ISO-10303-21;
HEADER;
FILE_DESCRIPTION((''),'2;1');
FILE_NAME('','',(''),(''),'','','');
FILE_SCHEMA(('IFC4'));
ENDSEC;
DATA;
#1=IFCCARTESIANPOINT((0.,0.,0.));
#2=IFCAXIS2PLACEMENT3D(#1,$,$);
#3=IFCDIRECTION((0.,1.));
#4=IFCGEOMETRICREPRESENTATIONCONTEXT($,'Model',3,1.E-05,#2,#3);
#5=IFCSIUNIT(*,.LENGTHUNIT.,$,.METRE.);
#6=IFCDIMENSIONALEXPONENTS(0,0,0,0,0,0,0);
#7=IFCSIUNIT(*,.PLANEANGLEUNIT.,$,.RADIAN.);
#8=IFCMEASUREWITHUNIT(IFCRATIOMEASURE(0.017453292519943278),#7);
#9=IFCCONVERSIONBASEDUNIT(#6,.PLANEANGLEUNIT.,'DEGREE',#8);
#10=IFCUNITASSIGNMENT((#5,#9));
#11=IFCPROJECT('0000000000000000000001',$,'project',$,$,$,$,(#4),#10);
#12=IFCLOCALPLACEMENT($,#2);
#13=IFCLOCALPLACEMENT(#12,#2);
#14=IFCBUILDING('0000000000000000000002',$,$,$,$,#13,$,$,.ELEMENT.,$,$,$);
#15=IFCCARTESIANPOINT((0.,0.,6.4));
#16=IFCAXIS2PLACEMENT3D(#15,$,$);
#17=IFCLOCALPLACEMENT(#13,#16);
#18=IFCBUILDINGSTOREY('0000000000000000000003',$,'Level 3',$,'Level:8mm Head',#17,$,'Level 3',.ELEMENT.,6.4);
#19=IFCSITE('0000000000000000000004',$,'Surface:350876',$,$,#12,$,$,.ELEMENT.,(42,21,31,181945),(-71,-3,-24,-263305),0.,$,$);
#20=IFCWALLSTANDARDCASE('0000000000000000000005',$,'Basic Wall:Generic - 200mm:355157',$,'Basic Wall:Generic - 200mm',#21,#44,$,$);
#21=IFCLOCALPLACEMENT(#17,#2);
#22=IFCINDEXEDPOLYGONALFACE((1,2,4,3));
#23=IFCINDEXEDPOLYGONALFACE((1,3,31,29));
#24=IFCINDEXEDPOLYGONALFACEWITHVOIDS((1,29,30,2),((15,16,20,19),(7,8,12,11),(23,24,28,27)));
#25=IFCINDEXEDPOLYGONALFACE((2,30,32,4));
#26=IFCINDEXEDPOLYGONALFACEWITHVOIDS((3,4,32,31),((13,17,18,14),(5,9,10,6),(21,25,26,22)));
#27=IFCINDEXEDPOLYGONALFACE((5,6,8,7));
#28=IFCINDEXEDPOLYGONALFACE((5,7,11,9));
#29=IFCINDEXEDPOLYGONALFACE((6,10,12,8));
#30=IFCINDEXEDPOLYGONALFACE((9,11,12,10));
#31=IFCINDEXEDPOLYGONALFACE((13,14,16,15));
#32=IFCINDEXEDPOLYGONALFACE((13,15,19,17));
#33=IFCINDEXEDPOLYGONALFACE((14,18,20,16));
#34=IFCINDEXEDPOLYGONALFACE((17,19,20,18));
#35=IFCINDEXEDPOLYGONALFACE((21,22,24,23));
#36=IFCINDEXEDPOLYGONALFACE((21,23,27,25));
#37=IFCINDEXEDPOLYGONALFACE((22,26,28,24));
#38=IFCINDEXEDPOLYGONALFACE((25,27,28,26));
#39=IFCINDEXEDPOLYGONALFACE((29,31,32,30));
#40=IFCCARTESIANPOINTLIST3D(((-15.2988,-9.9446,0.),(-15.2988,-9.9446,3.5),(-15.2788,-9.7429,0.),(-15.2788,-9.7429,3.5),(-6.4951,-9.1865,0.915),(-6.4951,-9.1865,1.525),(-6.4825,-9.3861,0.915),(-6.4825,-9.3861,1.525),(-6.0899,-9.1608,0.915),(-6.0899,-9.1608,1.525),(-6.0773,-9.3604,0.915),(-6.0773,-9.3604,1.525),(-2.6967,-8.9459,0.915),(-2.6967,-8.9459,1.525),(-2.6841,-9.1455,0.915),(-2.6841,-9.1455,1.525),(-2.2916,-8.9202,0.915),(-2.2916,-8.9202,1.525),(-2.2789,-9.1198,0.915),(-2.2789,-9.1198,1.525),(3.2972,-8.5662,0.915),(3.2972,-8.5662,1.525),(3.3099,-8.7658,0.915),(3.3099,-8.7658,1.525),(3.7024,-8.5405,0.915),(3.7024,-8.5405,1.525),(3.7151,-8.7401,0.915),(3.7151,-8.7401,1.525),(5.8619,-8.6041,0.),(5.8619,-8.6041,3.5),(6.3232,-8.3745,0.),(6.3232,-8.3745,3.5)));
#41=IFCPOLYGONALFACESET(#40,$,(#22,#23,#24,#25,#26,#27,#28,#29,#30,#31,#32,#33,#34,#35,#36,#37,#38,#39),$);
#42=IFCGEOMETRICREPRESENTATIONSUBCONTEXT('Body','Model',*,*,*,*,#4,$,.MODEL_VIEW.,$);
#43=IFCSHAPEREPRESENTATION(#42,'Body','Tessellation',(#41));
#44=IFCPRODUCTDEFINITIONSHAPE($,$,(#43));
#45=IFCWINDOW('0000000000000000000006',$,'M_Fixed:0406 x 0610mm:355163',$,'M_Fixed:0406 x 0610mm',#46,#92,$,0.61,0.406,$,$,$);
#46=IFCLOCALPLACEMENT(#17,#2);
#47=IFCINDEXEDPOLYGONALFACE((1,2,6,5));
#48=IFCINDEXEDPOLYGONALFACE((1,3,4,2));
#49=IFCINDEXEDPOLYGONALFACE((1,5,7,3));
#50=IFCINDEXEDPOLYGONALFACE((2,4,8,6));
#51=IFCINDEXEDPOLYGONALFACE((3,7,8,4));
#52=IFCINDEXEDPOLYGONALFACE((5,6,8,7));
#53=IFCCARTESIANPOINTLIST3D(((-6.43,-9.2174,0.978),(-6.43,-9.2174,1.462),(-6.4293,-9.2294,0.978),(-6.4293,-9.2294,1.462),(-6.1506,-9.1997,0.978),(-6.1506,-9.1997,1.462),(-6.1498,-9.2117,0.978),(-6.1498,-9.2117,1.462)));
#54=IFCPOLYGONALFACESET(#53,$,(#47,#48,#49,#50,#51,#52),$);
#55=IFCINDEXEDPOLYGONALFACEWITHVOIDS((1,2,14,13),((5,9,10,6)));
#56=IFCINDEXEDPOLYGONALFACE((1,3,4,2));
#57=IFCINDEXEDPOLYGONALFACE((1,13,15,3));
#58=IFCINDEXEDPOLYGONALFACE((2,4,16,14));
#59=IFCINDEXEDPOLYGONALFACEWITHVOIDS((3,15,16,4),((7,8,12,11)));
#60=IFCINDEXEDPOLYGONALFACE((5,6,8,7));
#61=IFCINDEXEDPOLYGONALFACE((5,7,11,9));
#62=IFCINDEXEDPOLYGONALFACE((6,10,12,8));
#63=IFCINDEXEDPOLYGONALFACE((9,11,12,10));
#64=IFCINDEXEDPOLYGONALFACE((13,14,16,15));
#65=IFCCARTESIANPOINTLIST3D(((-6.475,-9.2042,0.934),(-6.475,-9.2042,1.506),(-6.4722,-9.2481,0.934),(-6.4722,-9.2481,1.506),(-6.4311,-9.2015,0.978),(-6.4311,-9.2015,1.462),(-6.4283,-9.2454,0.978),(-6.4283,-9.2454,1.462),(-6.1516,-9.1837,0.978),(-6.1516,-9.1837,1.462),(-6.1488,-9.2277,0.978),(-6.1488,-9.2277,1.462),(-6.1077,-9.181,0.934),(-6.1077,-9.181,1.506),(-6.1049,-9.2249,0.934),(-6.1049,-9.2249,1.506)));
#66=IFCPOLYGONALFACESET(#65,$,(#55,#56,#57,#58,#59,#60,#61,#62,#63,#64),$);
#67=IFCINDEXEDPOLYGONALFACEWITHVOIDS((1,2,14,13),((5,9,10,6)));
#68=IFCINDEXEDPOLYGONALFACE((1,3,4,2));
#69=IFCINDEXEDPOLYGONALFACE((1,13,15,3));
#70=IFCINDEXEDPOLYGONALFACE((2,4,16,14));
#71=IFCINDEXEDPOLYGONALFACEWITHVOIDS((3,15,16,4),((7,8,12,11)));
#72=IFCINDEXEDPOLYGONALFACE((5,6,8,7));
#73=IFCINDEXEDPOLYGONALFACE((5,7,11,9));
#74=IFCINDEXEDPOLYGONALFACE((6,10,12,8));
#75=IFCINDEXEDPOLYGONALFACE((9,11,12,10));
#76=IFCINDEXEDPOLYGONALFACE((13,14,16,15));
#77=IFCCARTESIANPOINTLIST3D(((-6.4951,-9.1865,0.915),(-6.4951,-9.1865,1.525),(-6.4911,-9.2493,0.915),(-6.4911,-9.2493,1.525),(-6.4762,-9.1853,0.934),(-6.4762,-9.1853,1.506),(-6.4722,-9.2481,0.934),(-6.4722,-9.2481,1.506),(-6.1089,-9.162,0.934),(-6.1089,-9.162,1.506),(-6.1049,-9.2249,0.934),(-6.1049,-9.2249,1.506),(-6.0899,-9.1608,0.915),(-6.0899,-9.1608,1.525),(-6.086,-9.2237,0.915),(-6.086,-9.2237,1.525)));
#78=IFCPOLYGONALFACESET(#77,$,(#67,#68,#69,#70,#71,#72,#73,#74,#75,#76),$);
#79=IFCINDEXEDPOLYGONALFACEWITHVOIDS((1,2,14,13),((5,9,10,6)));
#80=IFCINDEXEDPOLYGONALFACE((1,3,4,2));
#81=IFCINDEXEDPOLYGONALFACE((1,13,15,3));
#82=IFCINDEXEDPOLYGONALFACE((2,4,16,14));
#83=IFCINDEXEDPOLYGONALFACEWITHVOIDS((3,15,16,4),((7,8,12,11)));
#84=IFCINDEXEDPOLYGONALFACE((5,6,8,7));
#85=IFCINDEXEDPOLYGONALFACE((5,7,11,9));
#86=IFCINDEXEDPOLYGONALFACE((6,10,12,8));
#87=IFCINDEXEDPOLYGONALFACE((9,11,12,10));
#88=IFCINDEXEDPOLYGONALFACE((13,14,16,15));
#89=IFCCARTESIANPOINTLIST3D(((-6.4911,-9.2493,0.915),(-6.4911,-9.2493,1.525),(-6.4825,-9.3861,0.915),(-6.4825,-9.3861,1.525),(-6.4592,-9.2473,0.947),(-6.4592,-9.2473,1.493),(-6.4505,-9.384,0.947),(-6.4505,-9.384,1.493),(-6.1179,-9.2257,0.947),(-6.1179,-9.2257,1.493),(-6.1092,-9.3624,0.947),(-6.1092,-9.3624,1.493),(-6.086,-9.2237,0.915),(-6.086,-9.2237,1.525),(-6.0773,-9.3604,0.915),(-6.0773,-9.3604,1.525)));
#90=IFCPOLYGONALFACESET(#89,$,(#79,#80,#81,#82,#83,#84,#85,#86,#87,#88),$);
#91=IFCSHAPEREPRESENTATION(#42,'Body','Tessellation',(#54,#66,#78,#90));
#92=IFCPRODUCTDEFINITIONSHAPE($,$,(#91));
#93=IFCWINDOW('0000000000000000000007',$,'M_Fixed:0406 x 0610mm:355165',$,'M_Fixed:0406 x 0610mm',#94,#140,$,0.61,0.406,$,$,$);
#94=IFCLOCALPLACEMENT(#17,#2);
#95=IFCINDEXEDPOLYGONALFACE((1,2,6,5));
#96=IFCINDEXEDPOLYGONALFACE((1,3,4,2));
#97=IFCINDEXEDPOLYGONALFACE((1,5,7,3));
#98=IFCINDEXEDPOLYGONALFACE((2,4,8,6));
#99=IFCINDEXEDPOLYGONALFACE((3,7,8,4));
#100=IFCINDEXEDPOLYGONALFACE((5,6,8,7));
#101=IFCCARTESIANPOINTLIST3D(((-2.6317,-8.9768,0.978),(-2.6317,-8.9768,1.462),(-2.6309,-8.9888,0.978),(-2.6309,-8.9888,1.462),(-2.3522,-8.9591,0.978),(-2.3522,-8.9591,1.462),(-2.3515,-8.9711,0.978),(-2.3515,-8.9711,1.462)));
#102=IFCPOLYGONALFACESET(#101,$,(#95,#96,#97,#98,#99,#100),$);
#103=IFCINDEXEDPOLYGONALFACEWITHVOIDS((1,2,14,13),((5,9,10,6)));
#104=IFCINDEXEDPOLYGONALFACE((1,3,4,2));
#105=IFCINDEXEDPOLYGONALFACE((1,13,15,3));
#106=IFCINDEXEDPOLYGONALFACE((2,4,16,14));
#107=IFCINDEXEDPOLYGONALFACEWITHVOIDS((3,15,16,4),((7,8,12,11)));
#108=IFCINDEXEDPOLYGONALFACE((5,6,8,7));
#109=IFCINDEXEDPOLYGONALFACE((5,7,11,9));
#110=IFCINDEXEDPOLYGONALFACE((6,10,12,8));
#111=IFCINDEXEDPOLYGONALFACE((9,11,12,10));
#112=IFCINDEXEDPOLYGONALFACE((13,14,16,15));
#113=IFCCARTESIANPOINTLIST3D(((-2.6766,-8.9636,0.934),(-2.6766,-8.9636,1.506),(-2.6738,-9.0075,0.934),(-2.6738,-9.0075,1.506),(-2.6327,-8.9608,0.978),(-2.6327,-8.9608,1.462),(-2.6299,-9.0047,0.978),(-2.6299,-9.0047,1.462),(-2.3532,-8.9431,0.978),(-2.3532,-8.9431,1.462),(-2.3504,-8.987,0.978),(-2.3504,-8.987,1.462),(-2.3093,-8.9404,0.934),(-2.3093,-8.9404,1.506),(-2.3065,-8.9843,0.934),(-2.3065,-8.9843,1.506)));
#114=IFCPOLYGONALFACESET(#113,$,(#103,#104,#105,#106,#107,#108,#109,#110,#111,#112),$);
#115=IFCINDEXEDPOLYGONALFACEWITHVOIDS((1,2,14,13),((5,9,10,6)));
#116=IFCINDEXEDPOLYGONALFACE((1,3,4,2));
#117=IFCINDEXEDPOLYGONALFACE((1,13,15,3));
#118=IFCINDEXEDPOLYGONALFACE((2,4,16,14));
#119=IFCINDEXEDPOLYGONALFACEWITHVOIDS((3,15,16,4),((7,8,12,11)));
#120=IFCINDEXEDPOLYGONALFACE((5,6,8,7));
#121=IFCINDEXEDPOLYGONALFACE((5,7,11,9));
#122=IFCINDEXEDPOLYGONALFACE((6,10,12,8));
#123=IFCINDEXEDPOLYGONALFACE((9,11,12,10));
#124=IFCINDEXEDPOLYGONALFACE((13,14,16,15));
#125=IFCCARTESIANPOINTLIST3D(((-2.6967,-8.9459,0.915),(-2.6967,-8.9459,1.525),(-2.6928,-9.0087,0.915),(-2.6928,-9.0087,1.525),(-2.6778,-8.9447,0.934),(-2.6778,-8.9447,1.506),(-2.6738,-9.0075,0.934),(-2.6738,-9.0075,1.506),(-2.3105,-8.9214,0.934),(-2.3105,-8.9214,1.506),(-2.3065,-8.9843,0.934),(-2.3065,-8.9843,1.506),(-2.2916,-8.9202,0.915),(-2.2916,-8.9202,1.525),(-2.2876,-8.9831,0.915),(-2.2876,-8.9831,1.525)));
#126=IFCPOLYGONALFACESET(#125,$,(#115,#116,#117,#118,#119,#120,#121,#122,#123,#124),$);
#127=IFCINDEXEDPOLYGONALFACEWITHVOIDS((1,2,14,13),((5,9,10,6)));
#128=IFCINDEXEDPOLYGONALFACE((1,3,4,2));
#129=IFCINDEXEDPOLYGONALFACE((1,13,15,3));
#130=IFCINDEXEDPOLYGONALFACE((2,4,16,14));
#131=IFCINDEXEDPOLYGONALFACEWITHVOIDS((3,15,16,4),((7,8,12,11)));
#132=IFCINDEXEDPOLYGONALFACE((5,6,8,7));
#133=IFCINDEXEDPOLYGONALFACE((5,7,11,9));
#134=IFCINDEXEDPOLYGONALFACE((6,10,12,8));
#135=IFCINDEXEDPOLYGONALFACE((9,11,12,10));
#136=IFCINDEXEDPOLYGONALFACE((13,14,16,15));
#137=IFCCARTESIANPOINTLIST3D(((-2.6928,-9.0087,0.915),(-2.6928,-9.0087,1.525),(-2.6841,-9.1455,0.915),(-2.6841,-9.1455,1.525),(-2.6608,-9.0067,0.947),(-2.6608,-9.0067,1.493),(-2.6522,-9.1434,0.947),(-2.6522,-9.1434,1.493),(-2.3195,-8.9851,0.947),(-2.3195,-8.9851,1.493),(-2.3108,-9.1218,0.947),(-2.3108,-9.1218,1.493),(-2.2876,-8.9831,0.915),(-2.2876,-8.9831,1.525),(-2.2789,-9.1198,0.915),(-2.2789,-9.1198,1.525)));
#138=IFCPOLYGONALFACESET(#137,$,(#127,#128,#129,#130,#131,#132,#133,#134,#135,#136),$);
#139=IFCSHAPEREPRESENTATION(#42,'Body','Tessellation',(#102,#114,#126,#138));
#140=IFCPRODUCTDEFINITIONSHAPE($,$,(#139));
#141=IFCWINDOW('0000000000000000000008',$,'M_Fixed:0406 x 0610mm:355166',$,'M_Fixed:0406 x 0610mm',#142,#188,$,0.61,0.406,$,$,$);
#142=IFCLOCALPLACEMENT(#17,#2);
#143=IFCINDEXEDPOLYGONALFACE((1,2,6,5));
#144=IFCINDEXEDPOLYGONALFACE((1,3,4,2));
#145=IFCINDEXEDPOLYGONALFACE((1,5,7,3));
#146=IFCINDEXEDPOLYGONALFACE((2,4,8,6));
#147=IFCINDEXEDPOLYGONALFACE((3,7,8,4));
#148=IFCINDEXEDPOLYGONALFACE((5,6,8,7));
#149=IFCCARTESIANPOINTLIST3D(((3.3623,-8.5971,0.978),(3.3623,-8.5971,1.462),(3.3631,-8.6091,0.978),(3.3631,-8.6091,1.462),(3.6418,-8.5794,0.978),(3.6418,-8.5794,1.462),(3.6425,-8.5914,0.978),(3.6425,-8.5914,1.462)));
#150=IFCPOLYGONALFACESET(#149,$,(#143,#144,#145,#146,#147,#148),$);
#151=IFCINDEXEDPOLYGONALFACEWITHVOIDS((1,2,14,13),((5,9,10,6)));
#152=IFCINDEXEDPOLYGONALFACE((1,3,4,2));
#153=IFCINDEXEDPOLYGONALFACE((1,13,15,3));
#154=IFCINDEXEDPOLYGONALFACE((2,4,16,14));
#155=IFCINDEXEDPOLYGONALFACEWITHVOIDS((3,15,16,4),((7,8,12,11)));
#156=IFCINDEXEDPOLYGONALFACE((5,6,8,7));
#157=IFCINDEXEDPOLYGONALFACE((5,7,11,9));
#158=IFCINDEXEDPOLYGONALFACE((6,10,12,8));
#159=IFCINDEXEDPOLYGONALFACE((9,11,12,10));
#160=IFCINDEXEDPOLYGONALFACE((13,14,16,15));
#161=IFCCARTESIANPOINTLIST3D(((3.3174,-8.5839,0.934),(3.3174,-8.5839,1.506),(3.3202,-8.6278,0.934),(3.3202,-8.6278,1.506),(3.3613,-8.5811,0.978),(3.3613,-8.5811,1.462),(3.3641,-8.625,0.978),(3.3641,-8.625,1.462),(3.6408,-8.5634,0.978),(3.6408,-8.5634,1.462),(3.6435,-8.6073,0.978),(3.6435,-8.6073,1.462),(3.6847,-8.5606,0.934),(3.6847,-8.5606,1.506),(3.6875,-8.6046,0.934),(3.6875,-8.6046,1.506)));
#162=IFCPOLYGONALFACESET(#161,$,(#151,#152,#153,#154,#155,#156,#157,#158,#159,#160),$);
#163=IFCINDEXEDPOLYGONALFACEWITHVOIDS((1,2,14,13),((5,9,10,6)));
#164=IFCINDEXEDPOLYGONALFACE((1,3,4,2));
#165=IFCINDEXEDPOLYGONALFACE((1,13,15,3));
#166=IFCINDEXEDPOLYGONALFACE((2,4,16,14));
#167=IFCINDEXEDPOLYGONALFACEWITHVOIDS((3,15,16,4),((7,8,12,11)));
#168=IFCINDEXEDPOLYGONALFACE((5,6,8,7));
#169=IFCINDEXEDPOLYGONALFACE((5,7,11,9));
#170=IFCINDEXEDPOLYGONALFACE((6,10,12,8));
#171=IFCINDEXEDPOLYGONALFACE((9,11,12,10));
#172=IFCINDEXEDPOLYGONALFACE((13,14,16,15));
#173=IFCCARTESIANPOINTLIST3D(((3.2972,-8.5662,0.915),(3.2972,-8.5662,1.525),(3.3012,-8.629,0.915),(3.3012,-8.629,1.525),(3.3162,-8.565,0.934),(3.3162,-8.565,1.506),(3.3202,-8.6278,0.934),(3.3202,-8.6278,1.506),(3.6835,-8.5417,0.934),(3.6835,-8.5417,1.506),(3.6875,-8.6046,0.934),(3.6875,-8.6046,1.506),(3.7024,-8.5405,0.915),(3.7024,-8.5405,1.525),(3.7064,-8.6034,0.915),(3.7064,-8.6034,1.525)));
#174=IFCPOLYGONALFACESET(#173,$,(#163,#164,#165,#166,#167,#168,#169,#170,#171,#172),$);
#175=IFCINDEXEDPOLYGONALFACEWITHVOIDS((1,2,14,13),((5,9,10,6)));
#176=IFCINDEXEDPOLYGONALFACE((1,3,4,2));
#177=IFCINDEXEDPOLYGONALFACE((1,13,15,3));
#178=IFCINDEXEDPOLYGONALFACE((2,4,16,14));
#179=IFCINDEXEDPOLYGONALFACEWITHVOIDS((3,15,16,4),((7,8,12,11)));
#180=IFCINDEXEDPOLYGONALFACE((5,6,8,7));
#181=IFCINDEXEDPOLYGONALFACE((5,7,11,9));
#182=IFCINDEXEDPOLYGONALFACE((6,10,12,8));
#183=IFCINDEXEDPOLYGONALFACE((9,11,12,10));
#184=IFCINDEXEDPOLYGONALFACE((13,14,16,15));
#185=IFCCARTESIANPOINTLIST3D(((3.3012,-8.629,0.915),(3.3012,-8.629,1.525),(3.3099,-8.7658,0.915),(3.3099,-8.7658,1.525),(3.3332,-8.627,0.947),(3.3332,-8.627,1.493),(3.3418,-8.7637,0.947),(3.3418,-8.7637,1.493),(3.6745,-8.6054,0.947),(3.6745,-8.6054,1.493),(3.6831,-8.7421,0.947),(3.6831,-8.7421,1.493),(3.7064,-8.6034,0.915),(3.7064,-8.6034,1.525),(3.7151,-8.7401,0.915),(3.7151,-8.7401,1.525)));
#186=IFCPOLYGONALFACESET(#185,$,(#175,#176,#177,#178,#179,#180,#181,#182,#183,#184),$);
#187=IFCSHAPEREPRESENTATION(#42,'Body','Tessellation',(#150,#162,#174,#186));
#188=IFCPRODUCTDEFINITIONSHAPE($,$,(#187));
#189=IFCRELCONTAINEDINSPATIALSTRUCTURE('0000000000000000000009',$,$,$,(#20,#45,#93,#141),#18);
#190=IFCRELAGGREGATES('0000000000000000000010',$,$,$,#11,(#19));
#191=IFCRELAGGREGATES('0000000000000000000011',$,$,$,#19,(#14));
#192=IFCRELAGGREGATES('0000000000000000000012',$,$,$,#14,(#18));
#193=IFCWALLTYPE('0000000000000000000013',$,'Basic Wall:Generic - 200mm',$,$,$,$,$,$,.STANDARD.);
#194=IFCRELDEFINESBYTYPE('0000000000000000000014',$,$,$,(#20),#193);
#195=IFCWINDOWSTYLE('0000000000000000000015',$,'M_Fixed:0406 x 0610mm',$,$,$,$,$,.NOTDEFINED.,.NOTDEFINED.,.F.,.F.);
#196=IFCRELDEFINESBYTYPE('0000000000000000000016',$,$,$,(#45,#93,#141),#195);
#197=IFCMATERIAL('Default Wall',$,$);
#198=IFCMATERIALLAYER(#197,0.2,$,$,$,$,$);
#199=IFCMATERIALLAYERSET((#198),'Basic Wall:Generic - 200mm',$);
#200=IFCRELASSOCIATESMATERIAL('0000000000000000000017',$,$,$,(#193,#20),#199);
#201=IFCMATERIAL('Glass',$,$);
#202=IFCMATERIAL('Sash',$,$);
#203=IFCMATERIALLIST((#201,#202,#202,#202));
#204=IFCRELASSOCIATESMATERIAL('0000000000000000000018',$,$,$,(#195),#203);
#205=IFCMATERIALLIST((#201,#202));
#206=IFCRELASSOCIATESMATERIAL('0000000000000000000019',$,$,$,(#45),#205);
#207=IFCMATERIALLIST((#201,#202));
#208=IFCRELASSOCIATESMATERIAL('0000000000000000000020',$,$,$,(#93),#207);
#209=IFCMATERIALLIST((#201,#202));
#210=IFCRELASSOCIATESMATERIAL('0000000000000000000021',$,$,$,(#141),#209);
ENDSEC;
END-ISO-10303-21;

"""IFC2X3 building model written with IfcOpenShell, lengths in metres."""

from ifc_helpers import new_model, entity, si_unit, converted_unit, direction, frame, frame_2d, origin, place, context, subcontext, project, spatial, polyline, rectangle, outline, extrude, source, transform, mapped, material, material_list, layer, layer_set, layer_usage, type_object, type_shapes, element, fill, save


model = new_model("IFC2X3")

# Units and contexts
model_context = context("Model", 3, precision=1e-05, world=origin(), true_north=direction((0.0, 1.0)))
body_context = subcontext(model_context, "Body", "Model", "MODEL_VIEW")
ifc_project = project(units=[si_unit("LENGTHUNIT", "METRE"), converted_unit("PLANEANGLEUNIT", "DEGREE", entity("IfcRatioMeasure", 0.017453292519943278), si_unit("PLANEANGLEUNIT", "RADIAN"), dimensions=[0, 0, 0, 0, 0, 0, 0])], contexts=[model_context])

# Site, building, storey
site_placement = place(None, origin())
site = spatial("IfcSite", under=ifc_project, at=site_placement, Name="Surface:350876", CompositionType="ELEMENT", RefLatitude=(42, 21, 31, 181945), RefLongitude=(-71, -3, -24, -263305), RefElevation=0.0)
building_placement = place(site_placement, origin())
building = spatial("IfcBuilding", under=site, at=building_placement, CompositionType="ELEMENT")
storey_placement = place(building_placement, frame((0.0, 0.0, 6.4)))
storey = spatial("IfcBuildingStorey", under=building, at=storey_placement, Name="Level 3", ObjectType="Level:8mm Head", LongName="Level 3", CompositionType="ELEMENT", Elevation=6.4)

# Wall, openings, windows
ifc_material_1 = material(Name="Default Wall")
ifc_layer_1 = layer(ifc_material_1, 0.2)
ifc_layer_set_1 = layer_set([ifc_layer_1], Name="Basic Wall:Generic - 200mm")
wall_type_1 = type_object("IfcWallType", Name="Basic Wall:Generic - 200mm", PredefinedType="STANDARD", material=ifc_layer_set_1)
ifc_material_2 = material(Name="Glass")
ifc_material_3 = material(Name="Sash")
ifc_material_list_1 = material_list([ifc_material_2, ifc_material_3, ifc_material_3, ifc_material_3])
window_style = type_object("IfcWindowStyle", Name="M_Fixed:0406 x 0610mm", ConstructionType="NOTDEFINED", OperationType="NOTDEFINED", ParameterTakesPrecedence=False, Sizeable=False, material=ifc_material_list_1)
shared_shape_1 = source(origin(), body_context, "Body", "SweptSolid", [
    extrude(rectangle(XDim=0.012, YDim=0.28, at=frame_2d((0.0, 0.0), x_axis=(1.0, 0.0))), frame((0.203, 0.159, 0.063), z_axis=(0.0, 0.0, 1.0), x_axis=(0.0, -1.0, 0.0)), (0.0, 0.0, 1.0), 0.484),
    extrude(outline(polyline([(-0.184, -0.286), (0.184, -0.286), (0.184, 0.286), (-0.184, 0.286), (-0.184, -0.286)]), holes=[polyline([(-0.14, -0.242), (-0.14, 0.242), (0.14, 0.242), (0.14, -0.242), (-0.14, -0.242)])]), frame((0.203, 0.137, 0.305), z_axis=(0.0, 1.0, 0.0), x_axis=(1.0, 0.0, 0.0)), (0.0, 0.0, 1.0), 0.044),
    extrude(outline(polyline([(-0.203, -0.305), (0.203, -0.305), (0.203, 0.305), (-0.203, 0.305), (-0.203, -0.305)]), holes=[polyline([(-0.184, -0.286), (-0.184, 0.286), (0.184, 0.286), (0.184, -0.286), (-0.184, -0.286)])]), frame((0.203, 0.137, 0.305), z_axis=(0.0, 1.0, 0.0), x_axis=(1.0, 0.0, 0.0)), (0.0, 0.0, 1.0), 0.063),
    extrude(outline(polyline([(-0.203, -0.305), (0.203, -0.305), (0.203, 0.305), (-0.203, 0.305), (-0.203, -0.305)]), holes=[polyline([(-0.171, -0.273), (-0.171, 0.273), (0.171, 0.273), (0.171, -0.273), (-0.171, -0.273)])]), frame((0.203, 0.0, 0.305), z_axis=(0.0, 1.0, 0.0), x_axis=(1.0, 0.0, 0.0)), (0.0, 0.0, 1.0), 0.137),
])
type_shapes(window_style, [shared_shape_1])
ifc_layer_usage_1 = layer_usage(ifc_layer_set_1, "AXIS2", "NEGATIVE", 0.1)
wall_1_placement = place(storey_placement, frame((-15.3051, -9.8448, 0.0), z_axis=(0.0, 0.0, 1.0), x_axis=(0.998, 0.063221, 0.0)))
wall_1 = element("IfcWallStandardCase", 1, at=wall_1_placement, inside=storey, type_object=wall_type_1, material=ifc_layer_usage_1, Name="Basic Wall:Generic - 200mm:355157", ObjectType="Basic Wall:Generic - 200mm", context=body_context, shape_type="SweptSolid", body=[
    extrude(outline(polyline([(21.2031, -0.1), (21.6779, 0.1), (21.1627, 0.1), (2.7484, 0.1), (2.5301, 0.1), (0.0326, 0.1), (0.0, -0.1), (21.2031, -0.1)])), origin(), (0.0, 0.0, 1.0), 3.5),
])
opening_1_placement = place(wall_1_placement, frame((8.8339, -0.1, 0.915)))
opening_1 = element("IfcOpeningElement", 2, at=opening_1_placement, cuts=wall_1, ObjectType="Opening", context=body_context, shape_type="SweptSolid", body=[
    extrude(rectangle(XDim=0.61, YDim=0.406, at=frame_2d((0.305, 0.203), x_axis=(1.0, 0.0))), frame((0.0, 0.0, 0.0), z_axis=(0.0, 1.0, 0.0), x_axis=(0.0, 0.0, 1.0)), (0.0, 0.0, 1.0), 0.2),
])
opening_2_placement = place(wall_1_placement, frame((12.6399, -0.1, 0.915)))
opening_2 = element("IfcOpeningElement", 3, at=opening_2_placement, cuts=wall_1, ObjectType="Opening", context=body_context, shape_type="SweptSolid", body=[
    extrude(rectangle(XDim=0.61, YDim=0.406, at=frame_2d((0.305, 0.203), x_axis=(1.0, 0.0))), frame((0.0, 0.0, 0.0), z_axis=(0.0, 1.0, 0.0), x_axis=(0.0, 0.0, 1.0)), (0.0, 0.0, 1.0), 0.2),
])
opening_3_placement = place(wall_1_placement, frame((18.6459, -0.1, 0.915)))
opening_3 = element("IfcOpeningElement", 4, at=opening_3_placement, cuts=wall_1, ObjectType="Opening", context=body_context, shape_type="SweptSolid", body=[
    extrude(rectangle(XDim=0.61, YDim=0.406, at=frame_2d((0.305, 0.203), x_axis=(1.0, 0.0))), frame((0.0, 0.0, 0.0), z_axis=(0.0, 1.0, 0.0), x_axis=(0.0, 0.0, 1.0)), (0.0, 0.0, 1.0), 0.2),
])
ifc_material_list_2 = material_list([ifc_material_2, ifc_material_3])
window_1_placement = place(opening_1_placement, origin())
window_1 = element("IfcWindow", 5, at=window_1_placement, inside=storey, type_object=window_style, material=ifc_material_list_2, Name="M_Fixed:0406 x 0610mm:355163", ObjectType="M_Fixed:0406 x 0610mm", OverallHeight=0.61, OverallWidth=0.406, context=body_context, shape_type="MappedRepresentation", body=[
    mapped(shared_shape_1, transform((0.0, 0.0, 0.0), scale=1.0)),
])
fill(opening_1, window_1)
ifc_material_list_3 = material_list([ifc_material_2, ifc_material_3])
window_2_placement = place(opening_2_placement, origin())
window_2 = element("IfcWindow", 6, at=window_2_placement, inside=storey, type_object=window_style, material=ifc_material_list_3, Name="M_Fixed:0406 x 0610mm:355165", ObjectType="M_Fixed:0406 x 0610mm", OverallHeight=0.61, OverallWidth=0.406, context=body_context, shape_type="MappedRepresentation", body=[
    mapped(shared_shape_1, transform((0.0, 0.0, 0.0), scale=1.0)),
])
fill(opening_2, window_2)
ifc_material_list_4 = material_list([ifc_material_2, ifc_material_3])
window_3_placement = place(opening_3_placement, origin())
window_3 = element("IfcWindow", 7, at=window_3_placement, inside=storey, type_object=window_style, material=ifc_material_list_4, Name="M_Fixed:0406 x 0610mm:355166", ObjectType="M_Fixed:0406 x 0610mm", OverallHeight=0.61, OverallWidth=0.406, context=body_context, shape_type="MappedRepresentation", body=[
    mapped(shared_shape_1, transform((0.0, 0.0, 0.0), scale=1.0)),
])
fill(opening_3, window_3)

save(model, "model.ifc")
